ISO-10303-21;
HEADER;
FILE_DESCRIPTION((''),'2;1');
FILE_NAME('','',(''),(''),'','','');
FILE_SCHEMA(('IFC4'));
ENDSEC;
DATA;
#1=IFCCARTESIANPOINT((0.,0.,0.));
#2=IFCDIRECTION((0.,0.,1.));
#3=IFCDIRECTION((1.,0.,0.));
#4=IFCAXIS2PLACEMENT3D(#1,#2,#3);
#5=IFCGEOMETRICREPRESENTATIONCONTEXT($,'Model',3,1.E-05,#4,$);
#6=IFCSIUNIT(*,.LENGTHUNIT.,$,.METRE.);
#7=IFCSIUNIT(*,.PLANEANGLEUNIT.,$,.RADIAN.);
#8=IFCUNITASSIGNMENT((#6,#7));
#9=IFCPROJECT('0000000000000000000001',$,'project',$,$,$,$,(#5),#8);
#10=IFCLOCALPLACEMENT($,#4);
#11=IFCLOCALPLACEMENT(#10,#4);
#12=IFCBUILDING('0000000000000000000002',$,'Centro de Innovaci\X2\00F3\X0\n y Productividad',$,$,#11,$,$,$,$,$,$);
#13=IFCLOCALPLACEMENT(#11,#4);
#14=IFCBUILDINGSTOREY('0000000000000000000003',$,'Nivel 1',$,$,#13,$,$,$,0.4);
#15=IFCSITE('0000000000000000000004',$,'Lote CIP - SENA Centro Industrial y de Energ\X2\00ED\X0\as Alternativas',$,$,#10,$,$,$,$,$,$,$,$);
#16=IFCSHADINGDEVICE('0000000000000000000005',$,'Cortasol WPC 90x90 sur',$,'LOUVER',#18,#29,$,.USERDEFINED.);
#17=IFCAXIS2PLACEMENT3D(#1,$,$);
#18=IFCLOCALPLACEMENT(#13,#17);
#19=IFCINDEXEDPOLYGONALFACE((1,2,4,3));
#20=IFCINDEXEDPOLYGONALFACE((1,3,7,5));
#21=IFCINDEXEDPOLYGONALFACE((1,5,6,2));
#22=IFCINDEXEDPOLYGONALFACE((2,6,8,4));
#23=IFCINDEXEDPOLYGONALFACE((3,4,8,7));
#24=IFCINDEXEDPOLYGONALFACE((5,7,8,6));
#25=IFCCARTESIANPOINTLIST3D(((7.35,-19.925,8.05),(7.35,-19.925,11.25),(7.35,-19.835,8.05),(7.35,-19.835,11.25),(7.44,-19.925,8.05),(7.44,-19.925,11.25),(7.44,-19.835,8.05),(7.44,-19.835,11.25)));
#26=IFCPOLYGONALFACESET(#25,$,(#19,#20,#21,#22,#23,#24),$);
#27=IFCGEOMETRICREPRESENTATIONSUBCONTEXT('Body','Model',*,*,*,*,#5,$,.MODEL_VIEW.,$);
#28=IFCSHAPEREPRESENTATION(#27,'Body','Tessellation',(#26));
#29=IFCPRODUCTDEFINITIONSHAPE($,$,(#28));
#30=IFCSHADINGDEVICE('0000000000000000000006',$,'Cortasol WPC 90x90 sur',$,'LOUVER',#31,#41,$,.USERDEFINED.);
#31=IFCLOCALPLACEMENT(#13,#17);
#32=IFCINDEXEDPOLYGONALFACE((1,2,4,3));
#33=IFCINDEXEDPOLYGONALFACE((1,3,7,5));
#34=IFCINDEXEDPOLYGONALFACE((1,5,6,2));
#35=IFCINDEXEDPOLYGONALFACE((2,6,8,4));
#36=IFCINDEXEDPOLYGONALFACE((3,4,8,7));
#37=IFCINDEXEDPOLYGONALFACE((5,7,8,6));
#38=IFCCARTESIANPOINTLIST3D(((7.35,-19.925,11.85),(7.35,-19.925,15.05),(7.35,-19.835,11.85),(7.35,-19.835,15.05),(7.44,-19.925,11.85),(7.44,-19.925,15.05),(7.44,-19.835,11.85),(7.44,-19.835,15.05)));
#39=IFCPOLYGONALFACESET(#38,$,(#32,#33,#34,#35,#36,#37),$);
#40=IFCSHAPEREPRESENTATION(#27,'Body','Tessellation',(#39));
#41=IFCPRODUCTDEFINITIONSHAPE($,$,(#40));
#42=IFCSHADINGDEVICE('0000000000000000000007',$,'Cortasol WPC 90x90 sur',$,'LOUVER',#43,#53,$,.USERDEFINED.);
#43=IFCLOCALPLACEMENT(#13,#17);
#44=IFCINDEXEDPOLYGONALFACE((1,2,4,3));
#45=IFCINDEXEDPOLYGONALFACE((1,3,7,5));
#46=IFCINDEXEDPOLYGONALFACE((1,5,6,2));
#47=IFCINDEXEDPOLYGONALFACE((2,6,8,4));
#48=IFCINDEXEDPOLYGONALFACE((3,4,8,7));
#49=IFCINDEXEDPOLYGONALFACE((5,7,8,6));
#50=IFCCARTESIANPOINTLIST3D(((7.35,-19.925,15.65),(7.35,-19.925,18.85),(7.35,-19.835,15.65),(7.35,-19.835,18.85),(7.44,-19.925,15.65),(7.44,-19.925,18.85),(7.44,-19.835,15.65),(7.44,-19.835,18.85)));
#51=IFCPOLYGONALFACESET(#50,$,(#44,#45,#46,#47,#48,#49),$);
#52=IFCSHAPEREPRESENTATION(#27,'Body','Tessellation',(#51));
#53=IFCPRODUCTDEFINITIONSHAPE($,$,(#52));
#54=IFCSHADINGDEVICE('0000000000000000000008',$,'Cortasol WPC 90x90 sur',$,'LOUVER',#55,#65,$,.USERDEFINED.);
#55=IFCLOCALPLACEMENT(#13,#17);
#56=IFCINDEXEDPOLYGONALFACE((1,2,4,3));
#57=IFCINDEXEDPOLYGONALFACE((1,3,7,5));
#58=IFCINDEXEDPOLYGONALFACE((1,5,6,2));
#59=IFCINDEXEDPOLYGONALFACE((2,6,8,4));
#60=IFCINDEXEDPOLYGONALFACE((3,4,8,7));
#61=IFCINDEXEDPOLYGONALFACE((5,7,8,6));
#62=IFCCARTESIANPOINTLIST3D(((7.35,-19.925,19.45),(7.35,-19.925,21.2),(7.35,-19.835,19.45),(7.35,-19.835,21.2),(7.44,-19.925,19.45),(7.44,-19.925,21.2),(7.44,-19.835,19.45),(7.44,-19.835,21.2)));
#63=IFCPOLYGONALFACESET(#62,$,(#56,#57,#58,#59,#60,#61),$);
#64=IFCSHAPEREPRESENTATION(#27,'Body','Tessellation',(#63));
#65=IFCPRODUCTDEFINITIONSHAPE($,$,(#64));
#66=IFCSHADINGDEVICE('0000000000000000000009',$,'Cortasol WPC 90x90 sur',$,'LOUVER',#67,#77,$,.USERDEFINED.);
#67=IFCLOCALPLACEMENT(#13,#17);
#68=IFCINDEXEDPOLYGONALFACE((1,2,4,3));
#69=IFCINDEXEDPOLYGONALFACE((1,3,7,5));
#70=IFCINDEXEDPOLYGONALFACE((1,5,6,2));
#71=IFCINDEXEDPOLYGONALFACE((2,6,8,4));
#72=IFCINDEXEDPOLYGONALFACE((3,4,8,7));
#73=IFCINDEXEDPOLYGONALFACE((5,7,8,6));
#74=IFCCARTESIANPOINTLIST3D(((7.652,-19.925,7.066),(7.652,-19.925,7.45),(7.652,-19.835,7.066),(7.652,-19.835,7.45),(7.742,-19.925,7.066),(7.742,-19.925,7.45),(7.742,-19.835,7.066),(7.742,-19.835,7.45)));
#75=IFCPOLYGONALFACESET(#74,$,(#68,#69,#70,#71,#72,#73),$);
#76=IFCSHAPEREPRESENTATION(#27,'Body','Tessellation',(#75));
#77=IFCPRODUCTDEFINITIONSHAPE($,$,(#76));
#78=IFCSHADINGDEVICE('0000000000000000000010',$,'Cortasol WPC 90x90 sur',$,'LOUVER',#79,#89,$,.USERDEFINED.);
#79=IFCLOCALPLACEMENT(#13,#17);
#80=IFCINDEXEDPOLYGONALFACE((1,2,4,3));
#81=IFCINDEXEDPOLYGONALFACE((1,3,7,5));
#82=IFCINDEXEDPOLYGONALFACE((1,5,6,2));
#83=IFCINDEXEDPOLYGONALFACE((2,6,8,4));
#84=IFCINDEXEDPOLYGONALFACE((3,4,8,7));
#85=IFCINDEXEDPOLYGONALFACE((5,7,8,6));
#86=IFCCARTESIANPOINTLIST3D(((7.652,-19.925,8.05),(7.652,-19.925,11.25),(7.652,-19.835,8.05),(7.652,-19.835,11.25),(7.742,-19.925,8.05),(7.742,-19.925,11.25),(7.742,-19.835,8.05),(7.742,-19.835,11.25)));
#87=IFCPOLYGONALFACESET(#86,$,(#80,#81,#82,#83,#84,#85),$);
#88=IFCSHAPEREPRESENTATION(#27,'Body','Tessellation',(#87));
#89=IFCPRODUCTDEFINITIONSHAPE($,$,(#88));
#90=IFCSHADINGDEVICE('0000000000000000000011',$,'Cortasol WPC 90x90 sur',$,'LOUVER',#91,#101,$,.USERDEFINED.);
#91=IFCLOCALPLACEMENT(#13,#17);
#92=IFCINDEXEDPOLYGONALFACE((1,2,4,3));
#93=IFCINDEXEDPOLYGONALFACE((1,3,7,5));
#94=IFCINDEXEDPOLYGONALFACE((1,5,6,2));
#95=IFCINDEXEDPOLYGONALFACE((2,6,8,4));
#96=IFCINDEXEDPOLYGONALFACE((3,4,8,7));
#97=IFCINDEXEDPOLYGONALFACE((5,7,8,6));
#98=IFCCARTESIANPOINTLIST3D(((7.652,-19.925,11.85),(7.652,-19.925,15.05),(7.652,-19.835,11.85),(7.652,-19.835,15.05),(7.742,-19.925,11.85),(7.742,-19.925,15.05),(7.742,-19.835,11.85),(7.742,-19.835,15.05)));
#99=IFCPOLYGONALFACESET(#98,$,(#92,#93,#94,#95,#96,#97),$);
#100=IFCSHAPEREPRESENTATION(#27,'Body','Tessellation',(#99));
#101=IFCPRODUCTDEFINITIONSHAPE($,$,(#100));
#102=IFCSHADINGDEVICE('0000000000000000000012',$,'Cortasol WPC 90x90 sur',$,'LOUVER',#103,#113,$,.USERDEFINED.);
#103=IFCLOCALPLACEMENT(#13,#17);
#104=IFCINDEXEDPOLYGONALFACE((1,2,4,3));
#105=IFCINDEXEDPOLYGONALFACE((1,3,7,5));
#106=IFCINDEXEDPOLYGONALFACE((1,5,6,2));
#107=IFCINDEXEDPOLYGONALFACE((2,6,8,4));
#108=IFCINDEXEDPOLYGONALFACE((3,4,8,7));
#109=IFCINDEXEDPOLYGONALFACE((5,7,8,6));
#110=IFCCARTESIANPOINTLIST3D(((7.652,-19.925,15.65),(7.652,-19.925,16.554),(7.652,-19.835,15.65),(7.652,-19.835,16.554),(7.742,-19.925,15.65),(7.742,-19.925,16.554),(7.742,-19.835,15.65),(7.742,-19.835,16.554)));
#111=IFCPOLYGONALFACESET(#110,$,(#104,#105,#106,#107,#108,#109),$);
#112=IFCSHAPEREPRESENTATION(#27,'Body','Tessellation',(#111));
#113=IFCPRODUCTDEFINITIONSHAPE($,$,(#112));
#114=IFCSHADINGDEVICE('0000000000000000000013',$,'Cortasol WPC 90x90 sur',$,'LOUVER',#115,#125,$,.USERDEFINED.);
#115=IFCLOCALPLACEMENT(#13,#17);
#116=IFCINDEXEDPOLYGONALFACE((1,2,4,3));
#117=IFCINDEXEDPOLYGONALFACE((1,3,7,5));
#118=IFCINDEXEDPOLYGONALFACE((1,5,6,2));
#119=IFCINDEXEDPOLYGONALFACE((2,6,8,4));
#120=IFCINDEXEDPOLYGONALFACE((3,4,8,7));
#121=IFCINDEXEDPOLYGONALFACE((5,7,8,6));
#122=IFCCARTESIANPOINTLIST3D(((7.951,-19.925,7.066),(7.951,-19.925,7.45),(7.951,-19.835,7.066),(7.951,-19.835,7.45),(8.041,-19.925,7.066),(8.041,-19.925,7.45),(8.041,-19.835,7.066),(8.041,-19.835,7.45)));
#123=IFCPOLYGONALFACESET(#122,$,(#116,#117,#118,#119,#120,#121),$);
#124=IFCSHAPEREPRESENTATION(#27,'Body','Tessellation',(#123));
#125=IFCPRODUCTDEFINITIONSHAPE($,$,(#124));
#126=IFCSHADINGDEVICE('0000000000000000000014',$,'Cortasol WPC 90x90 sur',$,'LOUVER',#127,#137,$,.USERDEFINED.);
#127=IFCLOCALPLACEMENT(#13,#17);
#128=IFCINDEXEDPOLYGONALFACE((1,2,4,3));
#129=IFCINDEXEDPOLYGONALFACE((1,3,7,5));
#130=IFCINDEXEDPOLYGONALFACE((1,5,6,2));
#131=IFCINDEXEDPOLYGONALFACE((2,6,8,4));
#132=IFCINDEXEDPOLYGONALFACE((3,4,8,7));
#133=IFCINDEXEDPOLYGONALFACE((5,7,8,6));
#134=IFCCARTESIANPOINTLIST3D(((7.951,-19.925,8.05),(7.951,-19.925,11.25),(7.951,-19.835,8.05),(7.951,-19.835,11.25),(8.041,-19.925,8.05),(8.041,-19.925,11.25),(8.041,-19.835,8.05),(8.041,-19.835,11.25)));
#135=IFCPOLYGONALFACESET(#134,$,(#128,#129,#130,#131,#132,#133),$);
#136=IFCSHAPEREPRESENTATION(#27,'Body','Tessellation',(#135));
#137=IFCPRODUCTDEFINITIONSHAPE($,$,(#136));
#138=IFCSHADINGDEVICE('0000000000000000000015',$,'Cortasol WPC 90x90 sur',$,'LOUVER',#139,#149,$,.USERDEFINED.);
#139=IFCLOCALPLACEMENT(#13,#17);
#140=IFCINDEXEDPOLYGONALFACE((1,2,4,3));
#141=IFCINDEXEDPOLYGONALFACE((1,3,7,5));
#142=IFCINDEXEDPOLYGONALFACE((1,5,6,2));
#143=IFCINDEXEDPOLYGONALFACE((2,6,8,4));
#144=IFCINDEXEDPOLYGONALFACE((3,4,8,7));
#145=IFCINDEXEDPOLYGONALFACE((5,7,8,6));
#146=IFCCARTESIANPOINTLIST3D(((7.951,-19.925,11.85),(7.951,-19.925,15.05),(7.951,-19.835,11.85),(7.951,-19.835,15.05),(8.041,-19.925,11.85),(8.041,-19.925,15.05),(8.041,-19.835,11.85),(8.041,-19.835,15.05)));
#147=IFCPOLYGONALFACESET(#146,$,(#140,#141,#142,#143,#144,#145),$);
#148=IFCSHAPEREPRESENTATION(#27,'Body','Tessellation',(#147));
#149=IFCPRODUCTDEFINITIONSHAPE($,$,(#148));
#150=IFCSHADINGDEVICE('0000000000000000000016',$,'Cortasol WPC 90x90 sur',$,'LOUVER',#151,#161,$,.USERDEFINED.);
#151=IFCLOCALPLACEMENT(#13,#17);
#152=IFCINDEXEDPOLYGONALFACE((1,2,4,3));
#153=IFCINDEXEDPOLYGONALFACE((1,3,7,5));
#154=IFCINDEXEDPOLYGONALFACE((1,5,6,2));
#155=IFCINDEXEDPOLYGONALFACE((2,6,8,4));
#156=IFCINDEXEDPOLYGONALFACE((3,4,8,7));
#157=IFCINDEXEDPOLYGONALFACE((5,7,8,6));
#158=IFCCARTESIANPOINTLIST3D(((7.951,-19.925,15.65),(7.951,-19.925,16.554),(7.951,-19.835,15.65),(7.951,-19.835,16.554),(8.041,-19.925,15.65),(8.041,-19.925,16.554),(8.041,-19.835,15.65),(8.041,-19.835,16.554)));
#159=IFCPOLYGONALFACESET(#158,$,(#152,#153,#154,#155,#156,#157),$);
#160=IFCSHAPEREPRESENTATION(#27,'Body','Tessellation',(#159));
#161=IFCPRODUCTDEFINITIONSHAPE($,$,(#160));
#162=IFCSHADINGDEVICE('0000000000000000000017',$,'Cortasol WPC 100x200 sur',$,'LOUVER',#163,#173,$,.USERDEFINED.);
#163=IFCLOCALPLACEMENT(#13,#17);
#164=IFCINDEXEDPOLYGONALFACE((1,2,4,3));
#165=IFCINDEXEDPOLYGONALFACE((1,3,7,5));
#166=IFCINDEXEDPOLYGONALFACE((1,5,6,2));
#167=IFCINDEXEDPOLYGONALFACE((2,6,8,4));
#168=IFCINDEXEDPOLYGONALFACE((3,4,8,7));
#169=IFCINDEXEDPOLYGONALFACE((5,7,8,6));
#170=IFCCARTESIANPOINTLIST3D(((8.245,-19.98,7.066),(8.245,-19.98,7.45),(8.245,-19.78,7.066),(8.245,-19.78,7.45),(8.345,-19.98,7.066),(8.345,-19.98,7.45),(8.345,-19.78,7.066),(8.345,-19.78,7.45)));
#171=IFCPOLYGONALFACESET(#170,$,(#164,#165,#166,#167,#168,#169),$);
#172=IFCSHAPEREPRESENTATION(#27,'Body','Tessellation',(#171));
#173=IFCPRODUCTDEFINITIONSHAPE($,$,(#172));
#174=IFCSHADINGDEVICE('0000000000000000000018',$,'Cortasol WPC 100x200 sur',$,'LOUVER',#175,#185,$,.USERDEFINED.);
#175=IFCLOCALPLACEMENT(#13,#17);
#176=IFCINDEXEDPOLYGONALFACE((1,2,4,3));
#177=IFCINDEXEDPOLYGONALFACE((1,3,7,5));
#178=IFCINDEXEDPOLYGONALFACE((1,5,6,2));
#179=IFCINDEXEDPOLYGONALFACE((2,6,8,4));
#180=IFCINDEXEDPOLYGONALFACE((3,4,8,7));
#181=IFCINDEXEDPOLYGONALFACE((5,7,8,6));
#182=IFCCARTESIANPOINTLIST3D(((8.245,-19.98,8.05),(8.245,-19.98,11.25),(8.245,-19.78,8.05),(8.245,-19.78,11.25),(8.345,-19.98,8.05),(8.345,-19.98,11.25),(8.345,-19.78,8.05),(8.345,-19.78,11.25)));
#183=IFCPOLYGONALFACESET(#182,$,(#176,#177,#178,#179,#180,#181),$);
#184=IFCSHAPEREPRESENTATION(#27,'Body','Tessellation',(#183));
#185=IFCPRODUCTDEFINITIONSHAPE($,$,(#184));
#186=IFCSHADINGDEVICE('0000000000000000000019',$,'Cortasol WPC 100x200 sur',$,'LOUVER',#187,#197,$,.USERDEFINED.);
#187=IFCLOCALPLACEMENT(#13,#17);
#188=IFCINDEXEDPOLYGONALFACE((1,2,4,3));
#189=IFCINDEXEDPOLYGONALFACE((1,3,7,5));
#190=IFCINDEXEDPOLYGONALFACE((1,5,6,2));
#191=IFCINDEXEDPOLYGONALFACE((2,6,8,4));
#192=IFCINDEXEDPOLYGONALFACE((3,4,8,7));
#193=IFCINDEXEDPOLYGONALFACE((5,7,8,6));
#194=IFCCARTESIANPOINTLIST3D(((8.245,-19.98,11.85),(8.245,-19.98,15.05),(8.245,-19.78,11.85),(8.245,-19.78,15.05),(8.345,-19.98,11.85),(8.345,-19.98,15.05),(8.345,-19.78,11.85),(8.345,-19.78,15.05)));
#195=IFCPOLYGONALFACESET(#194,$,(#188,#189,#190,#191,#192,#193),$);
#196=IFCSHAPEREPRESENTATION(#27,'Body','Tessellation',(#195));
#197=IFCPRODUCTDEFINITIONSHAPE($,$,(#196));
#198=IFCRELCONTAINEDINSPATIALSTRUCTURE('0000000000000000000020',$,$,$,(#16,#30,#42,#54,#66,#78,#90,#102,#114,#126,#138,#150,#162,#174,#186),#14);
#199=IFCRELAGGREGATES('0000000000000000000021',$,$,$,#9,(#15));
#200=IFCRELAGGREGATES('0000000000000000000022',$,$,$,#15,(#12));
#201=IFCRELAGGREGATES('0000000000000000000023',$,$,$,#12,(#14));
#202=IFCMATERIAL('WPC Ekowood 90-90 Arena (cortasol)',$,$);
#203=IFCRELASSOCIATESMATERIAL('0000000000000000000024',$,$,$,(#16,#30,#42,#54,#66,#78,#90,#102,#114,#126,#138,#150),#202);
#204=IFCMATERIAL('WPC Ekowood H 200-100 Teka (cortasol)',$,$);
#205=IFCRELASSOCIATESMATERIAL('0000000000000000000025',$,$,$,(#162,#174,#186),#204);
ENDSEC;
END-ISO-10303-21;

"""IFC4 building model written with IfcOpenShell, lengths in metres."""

from ifc_helpers import new_model, si_unit, frame, origin_with_axes, place, context, subcontext, project, spatial, polyline, outline, extrude, material, element, save


model = new_model("IFC4")

# Units and contexts
model_context = context("Model", 3, precision=1e-05, world=origin_with_axes())
body_context = subcontext(model_context, "Body", "Model", "MODEL_VIEW")
ifc_project = project(units=[si_unit("LENGTHUNIT", "METRE"), si_unit("PLANEANGLEUNIT", "RADIAN")], contexts=[model_context])

# Site, building, storey
site_placement = place(None, origin_with_axes())
site = spatial("IfcSite", under=ifc_project, at=site_placement, Name="Lote CIP - SENA Centro Industrial y de Energías Alternativas")
building_placement = place(site_placement, origin_with_axes())
building = spatial("IfcBuilding", under=site, at=building_placement, Name="Centro de Innovación y Productividad")
storey_placement = place(building_placement, origin_with_axes())
storey = spatial("IfcBuildingStorey", under=building, at=storey_placement, Name="Nivel 1", Elevation=0.4)

# Shading devices
ifc_material_1 = material(Name="WPC Ekowood 90-90 Arena (cortasol)")
shading_device_1_placement = place(storey_placement, origin_with_axes())
element("IfcShadingDevice", 1, at=shading_device_1_placement, inside=storey, material=ifc_material_1, Name="Cortasol WPC 90x90 sur", ObjectType="LOUVER", PredefinedType="USERDEFINED", context=body_context, shape_type="SweptSolid", body=[
    extrude(outline(polyline([(7.35, -19.925), (7.35, -19.835), (7.44, -19.835), (7.44, -19.925), (7.35, -19.925)])), frame((0.0, 0.0, 8.05)), (0.0, 0.0, 1.0), 3.2),
])
shading_device_2_placement = place(storey_placement, origin_with_axes())
element("IfcShadingDevice", 2, at=shading_device_2_placement, inside=storey, material=ifc_material_1, Name="Cortasol WPC 90x90 sur", ObjectType="LOUVER", PredefinedType="USERDEFINED", context=body_context, shape_type="SweptSolid", body=[
    extrude(outline(polyline([(7.35, -19.925), (7.35, -19.835), (7.44, -19.835), (7.44, -19.925), (7.35, -19.925)])), frame((0.0, 0.0, 11.85)), (0.0, 0.0, 1.0), 3.2),
])
shading_device_3_placement = place(storey_placement, origin_with_axes())
element("IfcShadingDevice", 3, at=shading_device_3_placement, inside=storey, material=ifc_material_1, Name="Cortasol WPC 90x90 sur", ObjectType="LOUVER", PredefinedType="USERDEFINED", context=body_context, shape_type="SweptSolid", body=[
    extrude(outline(polyline([(7.35, -19.925), (7.35, -19.835), (7.44, -19.835), (7.44, -19.925), (7.35, -19.925)])), frame((0.0, 0.0, 15.65)), (0.0, 0.0, 1.0), 3.2),
])
shading_device_4_placement = place(storey_placement, origin_with_axes())
element("IfcShadingDevice", 4, at=shading_device_4_placement, inside=storey, material=ifc_material_1, Name="Cortasol WPC 90x90 sur", ObjectType="LOUVER", PredefinedType="USERDEFINED", context=body_context, shape_type="SweptSolid", body=[
    extrude(outline(polyline([(7.35, -19.925), (7.35, -19.835), (7.44, -19.835), (7.44, -19.925), (7.35, -19.925)])), frame((0.0, 0.0, 19.45)), (0.0, 0.0, 1.0), 1.75),
])
shading_device_5_placement = place(storey_placement, origin_with_axes())
element("IfcShadingDevice", 5, at=shading_device_5_placement, inside=storey, material=ifc_material_1, Name="Cortasol WPC 90x90 sur", ObjectType="LOUVER", PredefinedType="USERDEFINED", context=body_context, shape_type="SweptSolid", body=[
    extrude(outline(polyline([(7.652, -19.925), (7.652, -19.835), (7.742, -19.835), (7.742, -19.925), (7.652, -19.925)])), frame((0.0, 0.0, 7.066)), (0.0, 0.0, 1.0), 0.384),
])
shading_device_6_placement = place(storey_placement, origin_with_axes())
element("IfcShadingDevice", 6, at=shading_device_6_placement, inside=storey, material=ifc_material_1, Name="Cortasol WPC 90x90 sur", ObjectType="LOUVER", PredefinedType="USERDEFINED", context=body_context, shape_type="SweptSolid", body=[
    extrude(outline(polyline([(7.652, -19.925), (7.652, -19.835), (7.742, -19.835), (7.742, -19.925), (7.652, -19.925)])), frame((0.0, 0.0, 8.05)), (0.0, 0.0, 1.0), 3.2),
])
shading_device_7_placement = place(storey_placement, origin_with_axes())
element("IfcShadingDevice", 7, at=shading_device_7_placement, inside=storey, material=ifc_material_1, Name="Cortasol WPC 90x90 sur", ObjectType="LOUVER", PredefinedType="USERDEFINED", context=body_context, shape_type="SweptSolid", body=[
    extrude(outline(polyline([(7.652, -19.925), (7.652, -19.835), (7.742, -19.835), (7.742, -19.925), (7.652, -19.925)])), frame((0.0, 0.0, 11.85)), (0.0, 0.0, 1.0), 3.2),
])
shading_device_8_placement = place(storey_placement, origin_with_axes())
element("IfcShadingDevice", 8, at=shading_device_8_placement, inside=storey, material=ifc_material_1, Name="Cortasol WPC 90x90 sur", ObjectType="LOUVER", PredefinedType="USERDEFINED", context=body_context, shape_type="SweptSolid", body=[
    extrude(outline(polyline([(7.652, -19.925), (7.652, -19.835), (7.742, -19.835), (7.742, -19.925), (7.652, -19.925)])), frame((0.0, 0.0, 15.65)), (0.0, 0.0, 1.0), 0.904),
])
shading_device_9_placement = place(storey_placement, origin_with_axes())
element("IfcShadingDevice", 9, at=shading_device_9_placement, inside=storey, material=ifc_material_1, Name="Cortasol WPC 90x90 sur", ObjectType="LOUVER", PredefinedType="USERDEFINED", context=body_context, shape_type="SweptSolid", body=[
    extrude(outline(polyline([(7.951, -19.925), (7.951, -19.835), (8.041, -19.835), (8.041, -19.925), (7.951, -19.925)])), frame((0.0, 0.0, 7.066)), (0.0, 0.0, 1.0), 0.384),
])
shading_device_10_placement = place(storey_placement, origin_with_axes())
element("IfcShadingDevice", 10, at=shading_device_10_placement, inside=storey, material=ifc_material_1, Name="Cortasol WPC 90x90 sur", ObjectType="LOUVER", PredefinedType="USERDEFINED", context=body_context, shape_type="SweptSolid", body=[
    extrude(outline(polyline([(7.951, -19.925), (7.951, -19.835), (8.041, -19.835), (8.041, -19.925), (7.951, -19.925)])), frame((0.0, 0.0, 8.05)), (0.0, 0.0, 1.0), 3.2),
])
shading_device_11_placement = place(storey_placement, origin_with_axes())
element("IfcShadingDevice", 11, at=shading_device_11_placement, inside=storey, material=ifc_material_1, Name="Cortasol WPC 90x90 sur", ObjectType="LOUVER", PredefinedType="USERDEFINED", context=body_context, shape_type="SweptSolid", body=[
    extrude(outline(polyline([(7.951, -19.925), (7.951, -19.835), (8.041, -19.835), (8.041, -19.925), (7.951, -19.925)])), frame((0.0, 0.0, 11.85)), (0.0, 0.0, 1.0), 3.2),
])
shading_device_12_placement = place(storey_placement, origin_with_axes())
element("IfcShadingDevice", 12, at=shading_device_12_placement, inside=storey, material=ifc_material_1, Name="Cortasol WPC 90x90 sur", ObjectType="LOUVER", PredefinedType="USERDEFINED", context=body_context, shape_type="SweptSolid", body=[
    extrude(outline(polyline([(7.951, -19.925), (7.951, -19.835), (8.041, -19.835), (8.041, -19.925), (7.951, -19.925)])), frame((0.0, 0.0, 15.65)), (0.0, 0.0, 1.0), 0.904),
])
ifc_material_2 = material(Name="WPC Ekowood H 200-100 Teka (cortasol)")
shading_device_13_placement = place(storey_placement, origin_with_axes())
element("IfcShadingDevice", 13, at=shading_device_13_placement, inside=storey, material=ifc_material_2, Name="Cortasol WPC 100x200 sur", ObjectType="LOUVER", PredefinedType="USERDEFINED", context=body_context, shape_type="SweptSolid", body=[
    extrude(outline(polyline([(8.245, -19.98), (8.245, -19.78), (8.345, -19.78), (8.345, -19.98), (8.245, -19.98)])), frame((0.0, 0.0, 7.066)), (0.0, 0.0, 1.0), 0.384),
])
shading_device_14_placement = place(storey_placement, origin_with_axes())
element("IfcShadingDevice", 14, at=shading_device_14_placement, inside=storey, material=ifc_material_2, Name="Cortasol WPC 100x200 sur", ObjectType="LOUVER", PredefinedType="USERDEFINED", context=body_context, shape_type="SweptSolid", body=[
    extrude(outline(polyline([(8.245, -19.98), (8.245, -19.78), (8.345, -19.78), (8.345, -19.98), (8.245, -19.98)])), frame((0.0, 0.0, 8.05)), (0.0, 0.0, 1.0), 3.2),
])
shading_device_15_placement = place(storey_placement, origin_with_axes())
element("IfcShadingDevice", 15, at=shading_device_15_placement, inside=storey, material=ifc_material_2, Name="Cortasol WPC 100x200 sur", ObjectType="LOUVER", PredefinedType="USERDEFINED", context=body_context, shape_type="SweptSolid", body=[
    extrude(outline(polyline([(8.245, -19.98), (8.245, -19.78), (8.345, -19.78), (8.345, -19.98), (8.245, -19.98)])), frame((0.0, 0.0, 11.85)), (0.0, 0.0, 1.0), 3.2),
])

save(model, "model.ifc")
